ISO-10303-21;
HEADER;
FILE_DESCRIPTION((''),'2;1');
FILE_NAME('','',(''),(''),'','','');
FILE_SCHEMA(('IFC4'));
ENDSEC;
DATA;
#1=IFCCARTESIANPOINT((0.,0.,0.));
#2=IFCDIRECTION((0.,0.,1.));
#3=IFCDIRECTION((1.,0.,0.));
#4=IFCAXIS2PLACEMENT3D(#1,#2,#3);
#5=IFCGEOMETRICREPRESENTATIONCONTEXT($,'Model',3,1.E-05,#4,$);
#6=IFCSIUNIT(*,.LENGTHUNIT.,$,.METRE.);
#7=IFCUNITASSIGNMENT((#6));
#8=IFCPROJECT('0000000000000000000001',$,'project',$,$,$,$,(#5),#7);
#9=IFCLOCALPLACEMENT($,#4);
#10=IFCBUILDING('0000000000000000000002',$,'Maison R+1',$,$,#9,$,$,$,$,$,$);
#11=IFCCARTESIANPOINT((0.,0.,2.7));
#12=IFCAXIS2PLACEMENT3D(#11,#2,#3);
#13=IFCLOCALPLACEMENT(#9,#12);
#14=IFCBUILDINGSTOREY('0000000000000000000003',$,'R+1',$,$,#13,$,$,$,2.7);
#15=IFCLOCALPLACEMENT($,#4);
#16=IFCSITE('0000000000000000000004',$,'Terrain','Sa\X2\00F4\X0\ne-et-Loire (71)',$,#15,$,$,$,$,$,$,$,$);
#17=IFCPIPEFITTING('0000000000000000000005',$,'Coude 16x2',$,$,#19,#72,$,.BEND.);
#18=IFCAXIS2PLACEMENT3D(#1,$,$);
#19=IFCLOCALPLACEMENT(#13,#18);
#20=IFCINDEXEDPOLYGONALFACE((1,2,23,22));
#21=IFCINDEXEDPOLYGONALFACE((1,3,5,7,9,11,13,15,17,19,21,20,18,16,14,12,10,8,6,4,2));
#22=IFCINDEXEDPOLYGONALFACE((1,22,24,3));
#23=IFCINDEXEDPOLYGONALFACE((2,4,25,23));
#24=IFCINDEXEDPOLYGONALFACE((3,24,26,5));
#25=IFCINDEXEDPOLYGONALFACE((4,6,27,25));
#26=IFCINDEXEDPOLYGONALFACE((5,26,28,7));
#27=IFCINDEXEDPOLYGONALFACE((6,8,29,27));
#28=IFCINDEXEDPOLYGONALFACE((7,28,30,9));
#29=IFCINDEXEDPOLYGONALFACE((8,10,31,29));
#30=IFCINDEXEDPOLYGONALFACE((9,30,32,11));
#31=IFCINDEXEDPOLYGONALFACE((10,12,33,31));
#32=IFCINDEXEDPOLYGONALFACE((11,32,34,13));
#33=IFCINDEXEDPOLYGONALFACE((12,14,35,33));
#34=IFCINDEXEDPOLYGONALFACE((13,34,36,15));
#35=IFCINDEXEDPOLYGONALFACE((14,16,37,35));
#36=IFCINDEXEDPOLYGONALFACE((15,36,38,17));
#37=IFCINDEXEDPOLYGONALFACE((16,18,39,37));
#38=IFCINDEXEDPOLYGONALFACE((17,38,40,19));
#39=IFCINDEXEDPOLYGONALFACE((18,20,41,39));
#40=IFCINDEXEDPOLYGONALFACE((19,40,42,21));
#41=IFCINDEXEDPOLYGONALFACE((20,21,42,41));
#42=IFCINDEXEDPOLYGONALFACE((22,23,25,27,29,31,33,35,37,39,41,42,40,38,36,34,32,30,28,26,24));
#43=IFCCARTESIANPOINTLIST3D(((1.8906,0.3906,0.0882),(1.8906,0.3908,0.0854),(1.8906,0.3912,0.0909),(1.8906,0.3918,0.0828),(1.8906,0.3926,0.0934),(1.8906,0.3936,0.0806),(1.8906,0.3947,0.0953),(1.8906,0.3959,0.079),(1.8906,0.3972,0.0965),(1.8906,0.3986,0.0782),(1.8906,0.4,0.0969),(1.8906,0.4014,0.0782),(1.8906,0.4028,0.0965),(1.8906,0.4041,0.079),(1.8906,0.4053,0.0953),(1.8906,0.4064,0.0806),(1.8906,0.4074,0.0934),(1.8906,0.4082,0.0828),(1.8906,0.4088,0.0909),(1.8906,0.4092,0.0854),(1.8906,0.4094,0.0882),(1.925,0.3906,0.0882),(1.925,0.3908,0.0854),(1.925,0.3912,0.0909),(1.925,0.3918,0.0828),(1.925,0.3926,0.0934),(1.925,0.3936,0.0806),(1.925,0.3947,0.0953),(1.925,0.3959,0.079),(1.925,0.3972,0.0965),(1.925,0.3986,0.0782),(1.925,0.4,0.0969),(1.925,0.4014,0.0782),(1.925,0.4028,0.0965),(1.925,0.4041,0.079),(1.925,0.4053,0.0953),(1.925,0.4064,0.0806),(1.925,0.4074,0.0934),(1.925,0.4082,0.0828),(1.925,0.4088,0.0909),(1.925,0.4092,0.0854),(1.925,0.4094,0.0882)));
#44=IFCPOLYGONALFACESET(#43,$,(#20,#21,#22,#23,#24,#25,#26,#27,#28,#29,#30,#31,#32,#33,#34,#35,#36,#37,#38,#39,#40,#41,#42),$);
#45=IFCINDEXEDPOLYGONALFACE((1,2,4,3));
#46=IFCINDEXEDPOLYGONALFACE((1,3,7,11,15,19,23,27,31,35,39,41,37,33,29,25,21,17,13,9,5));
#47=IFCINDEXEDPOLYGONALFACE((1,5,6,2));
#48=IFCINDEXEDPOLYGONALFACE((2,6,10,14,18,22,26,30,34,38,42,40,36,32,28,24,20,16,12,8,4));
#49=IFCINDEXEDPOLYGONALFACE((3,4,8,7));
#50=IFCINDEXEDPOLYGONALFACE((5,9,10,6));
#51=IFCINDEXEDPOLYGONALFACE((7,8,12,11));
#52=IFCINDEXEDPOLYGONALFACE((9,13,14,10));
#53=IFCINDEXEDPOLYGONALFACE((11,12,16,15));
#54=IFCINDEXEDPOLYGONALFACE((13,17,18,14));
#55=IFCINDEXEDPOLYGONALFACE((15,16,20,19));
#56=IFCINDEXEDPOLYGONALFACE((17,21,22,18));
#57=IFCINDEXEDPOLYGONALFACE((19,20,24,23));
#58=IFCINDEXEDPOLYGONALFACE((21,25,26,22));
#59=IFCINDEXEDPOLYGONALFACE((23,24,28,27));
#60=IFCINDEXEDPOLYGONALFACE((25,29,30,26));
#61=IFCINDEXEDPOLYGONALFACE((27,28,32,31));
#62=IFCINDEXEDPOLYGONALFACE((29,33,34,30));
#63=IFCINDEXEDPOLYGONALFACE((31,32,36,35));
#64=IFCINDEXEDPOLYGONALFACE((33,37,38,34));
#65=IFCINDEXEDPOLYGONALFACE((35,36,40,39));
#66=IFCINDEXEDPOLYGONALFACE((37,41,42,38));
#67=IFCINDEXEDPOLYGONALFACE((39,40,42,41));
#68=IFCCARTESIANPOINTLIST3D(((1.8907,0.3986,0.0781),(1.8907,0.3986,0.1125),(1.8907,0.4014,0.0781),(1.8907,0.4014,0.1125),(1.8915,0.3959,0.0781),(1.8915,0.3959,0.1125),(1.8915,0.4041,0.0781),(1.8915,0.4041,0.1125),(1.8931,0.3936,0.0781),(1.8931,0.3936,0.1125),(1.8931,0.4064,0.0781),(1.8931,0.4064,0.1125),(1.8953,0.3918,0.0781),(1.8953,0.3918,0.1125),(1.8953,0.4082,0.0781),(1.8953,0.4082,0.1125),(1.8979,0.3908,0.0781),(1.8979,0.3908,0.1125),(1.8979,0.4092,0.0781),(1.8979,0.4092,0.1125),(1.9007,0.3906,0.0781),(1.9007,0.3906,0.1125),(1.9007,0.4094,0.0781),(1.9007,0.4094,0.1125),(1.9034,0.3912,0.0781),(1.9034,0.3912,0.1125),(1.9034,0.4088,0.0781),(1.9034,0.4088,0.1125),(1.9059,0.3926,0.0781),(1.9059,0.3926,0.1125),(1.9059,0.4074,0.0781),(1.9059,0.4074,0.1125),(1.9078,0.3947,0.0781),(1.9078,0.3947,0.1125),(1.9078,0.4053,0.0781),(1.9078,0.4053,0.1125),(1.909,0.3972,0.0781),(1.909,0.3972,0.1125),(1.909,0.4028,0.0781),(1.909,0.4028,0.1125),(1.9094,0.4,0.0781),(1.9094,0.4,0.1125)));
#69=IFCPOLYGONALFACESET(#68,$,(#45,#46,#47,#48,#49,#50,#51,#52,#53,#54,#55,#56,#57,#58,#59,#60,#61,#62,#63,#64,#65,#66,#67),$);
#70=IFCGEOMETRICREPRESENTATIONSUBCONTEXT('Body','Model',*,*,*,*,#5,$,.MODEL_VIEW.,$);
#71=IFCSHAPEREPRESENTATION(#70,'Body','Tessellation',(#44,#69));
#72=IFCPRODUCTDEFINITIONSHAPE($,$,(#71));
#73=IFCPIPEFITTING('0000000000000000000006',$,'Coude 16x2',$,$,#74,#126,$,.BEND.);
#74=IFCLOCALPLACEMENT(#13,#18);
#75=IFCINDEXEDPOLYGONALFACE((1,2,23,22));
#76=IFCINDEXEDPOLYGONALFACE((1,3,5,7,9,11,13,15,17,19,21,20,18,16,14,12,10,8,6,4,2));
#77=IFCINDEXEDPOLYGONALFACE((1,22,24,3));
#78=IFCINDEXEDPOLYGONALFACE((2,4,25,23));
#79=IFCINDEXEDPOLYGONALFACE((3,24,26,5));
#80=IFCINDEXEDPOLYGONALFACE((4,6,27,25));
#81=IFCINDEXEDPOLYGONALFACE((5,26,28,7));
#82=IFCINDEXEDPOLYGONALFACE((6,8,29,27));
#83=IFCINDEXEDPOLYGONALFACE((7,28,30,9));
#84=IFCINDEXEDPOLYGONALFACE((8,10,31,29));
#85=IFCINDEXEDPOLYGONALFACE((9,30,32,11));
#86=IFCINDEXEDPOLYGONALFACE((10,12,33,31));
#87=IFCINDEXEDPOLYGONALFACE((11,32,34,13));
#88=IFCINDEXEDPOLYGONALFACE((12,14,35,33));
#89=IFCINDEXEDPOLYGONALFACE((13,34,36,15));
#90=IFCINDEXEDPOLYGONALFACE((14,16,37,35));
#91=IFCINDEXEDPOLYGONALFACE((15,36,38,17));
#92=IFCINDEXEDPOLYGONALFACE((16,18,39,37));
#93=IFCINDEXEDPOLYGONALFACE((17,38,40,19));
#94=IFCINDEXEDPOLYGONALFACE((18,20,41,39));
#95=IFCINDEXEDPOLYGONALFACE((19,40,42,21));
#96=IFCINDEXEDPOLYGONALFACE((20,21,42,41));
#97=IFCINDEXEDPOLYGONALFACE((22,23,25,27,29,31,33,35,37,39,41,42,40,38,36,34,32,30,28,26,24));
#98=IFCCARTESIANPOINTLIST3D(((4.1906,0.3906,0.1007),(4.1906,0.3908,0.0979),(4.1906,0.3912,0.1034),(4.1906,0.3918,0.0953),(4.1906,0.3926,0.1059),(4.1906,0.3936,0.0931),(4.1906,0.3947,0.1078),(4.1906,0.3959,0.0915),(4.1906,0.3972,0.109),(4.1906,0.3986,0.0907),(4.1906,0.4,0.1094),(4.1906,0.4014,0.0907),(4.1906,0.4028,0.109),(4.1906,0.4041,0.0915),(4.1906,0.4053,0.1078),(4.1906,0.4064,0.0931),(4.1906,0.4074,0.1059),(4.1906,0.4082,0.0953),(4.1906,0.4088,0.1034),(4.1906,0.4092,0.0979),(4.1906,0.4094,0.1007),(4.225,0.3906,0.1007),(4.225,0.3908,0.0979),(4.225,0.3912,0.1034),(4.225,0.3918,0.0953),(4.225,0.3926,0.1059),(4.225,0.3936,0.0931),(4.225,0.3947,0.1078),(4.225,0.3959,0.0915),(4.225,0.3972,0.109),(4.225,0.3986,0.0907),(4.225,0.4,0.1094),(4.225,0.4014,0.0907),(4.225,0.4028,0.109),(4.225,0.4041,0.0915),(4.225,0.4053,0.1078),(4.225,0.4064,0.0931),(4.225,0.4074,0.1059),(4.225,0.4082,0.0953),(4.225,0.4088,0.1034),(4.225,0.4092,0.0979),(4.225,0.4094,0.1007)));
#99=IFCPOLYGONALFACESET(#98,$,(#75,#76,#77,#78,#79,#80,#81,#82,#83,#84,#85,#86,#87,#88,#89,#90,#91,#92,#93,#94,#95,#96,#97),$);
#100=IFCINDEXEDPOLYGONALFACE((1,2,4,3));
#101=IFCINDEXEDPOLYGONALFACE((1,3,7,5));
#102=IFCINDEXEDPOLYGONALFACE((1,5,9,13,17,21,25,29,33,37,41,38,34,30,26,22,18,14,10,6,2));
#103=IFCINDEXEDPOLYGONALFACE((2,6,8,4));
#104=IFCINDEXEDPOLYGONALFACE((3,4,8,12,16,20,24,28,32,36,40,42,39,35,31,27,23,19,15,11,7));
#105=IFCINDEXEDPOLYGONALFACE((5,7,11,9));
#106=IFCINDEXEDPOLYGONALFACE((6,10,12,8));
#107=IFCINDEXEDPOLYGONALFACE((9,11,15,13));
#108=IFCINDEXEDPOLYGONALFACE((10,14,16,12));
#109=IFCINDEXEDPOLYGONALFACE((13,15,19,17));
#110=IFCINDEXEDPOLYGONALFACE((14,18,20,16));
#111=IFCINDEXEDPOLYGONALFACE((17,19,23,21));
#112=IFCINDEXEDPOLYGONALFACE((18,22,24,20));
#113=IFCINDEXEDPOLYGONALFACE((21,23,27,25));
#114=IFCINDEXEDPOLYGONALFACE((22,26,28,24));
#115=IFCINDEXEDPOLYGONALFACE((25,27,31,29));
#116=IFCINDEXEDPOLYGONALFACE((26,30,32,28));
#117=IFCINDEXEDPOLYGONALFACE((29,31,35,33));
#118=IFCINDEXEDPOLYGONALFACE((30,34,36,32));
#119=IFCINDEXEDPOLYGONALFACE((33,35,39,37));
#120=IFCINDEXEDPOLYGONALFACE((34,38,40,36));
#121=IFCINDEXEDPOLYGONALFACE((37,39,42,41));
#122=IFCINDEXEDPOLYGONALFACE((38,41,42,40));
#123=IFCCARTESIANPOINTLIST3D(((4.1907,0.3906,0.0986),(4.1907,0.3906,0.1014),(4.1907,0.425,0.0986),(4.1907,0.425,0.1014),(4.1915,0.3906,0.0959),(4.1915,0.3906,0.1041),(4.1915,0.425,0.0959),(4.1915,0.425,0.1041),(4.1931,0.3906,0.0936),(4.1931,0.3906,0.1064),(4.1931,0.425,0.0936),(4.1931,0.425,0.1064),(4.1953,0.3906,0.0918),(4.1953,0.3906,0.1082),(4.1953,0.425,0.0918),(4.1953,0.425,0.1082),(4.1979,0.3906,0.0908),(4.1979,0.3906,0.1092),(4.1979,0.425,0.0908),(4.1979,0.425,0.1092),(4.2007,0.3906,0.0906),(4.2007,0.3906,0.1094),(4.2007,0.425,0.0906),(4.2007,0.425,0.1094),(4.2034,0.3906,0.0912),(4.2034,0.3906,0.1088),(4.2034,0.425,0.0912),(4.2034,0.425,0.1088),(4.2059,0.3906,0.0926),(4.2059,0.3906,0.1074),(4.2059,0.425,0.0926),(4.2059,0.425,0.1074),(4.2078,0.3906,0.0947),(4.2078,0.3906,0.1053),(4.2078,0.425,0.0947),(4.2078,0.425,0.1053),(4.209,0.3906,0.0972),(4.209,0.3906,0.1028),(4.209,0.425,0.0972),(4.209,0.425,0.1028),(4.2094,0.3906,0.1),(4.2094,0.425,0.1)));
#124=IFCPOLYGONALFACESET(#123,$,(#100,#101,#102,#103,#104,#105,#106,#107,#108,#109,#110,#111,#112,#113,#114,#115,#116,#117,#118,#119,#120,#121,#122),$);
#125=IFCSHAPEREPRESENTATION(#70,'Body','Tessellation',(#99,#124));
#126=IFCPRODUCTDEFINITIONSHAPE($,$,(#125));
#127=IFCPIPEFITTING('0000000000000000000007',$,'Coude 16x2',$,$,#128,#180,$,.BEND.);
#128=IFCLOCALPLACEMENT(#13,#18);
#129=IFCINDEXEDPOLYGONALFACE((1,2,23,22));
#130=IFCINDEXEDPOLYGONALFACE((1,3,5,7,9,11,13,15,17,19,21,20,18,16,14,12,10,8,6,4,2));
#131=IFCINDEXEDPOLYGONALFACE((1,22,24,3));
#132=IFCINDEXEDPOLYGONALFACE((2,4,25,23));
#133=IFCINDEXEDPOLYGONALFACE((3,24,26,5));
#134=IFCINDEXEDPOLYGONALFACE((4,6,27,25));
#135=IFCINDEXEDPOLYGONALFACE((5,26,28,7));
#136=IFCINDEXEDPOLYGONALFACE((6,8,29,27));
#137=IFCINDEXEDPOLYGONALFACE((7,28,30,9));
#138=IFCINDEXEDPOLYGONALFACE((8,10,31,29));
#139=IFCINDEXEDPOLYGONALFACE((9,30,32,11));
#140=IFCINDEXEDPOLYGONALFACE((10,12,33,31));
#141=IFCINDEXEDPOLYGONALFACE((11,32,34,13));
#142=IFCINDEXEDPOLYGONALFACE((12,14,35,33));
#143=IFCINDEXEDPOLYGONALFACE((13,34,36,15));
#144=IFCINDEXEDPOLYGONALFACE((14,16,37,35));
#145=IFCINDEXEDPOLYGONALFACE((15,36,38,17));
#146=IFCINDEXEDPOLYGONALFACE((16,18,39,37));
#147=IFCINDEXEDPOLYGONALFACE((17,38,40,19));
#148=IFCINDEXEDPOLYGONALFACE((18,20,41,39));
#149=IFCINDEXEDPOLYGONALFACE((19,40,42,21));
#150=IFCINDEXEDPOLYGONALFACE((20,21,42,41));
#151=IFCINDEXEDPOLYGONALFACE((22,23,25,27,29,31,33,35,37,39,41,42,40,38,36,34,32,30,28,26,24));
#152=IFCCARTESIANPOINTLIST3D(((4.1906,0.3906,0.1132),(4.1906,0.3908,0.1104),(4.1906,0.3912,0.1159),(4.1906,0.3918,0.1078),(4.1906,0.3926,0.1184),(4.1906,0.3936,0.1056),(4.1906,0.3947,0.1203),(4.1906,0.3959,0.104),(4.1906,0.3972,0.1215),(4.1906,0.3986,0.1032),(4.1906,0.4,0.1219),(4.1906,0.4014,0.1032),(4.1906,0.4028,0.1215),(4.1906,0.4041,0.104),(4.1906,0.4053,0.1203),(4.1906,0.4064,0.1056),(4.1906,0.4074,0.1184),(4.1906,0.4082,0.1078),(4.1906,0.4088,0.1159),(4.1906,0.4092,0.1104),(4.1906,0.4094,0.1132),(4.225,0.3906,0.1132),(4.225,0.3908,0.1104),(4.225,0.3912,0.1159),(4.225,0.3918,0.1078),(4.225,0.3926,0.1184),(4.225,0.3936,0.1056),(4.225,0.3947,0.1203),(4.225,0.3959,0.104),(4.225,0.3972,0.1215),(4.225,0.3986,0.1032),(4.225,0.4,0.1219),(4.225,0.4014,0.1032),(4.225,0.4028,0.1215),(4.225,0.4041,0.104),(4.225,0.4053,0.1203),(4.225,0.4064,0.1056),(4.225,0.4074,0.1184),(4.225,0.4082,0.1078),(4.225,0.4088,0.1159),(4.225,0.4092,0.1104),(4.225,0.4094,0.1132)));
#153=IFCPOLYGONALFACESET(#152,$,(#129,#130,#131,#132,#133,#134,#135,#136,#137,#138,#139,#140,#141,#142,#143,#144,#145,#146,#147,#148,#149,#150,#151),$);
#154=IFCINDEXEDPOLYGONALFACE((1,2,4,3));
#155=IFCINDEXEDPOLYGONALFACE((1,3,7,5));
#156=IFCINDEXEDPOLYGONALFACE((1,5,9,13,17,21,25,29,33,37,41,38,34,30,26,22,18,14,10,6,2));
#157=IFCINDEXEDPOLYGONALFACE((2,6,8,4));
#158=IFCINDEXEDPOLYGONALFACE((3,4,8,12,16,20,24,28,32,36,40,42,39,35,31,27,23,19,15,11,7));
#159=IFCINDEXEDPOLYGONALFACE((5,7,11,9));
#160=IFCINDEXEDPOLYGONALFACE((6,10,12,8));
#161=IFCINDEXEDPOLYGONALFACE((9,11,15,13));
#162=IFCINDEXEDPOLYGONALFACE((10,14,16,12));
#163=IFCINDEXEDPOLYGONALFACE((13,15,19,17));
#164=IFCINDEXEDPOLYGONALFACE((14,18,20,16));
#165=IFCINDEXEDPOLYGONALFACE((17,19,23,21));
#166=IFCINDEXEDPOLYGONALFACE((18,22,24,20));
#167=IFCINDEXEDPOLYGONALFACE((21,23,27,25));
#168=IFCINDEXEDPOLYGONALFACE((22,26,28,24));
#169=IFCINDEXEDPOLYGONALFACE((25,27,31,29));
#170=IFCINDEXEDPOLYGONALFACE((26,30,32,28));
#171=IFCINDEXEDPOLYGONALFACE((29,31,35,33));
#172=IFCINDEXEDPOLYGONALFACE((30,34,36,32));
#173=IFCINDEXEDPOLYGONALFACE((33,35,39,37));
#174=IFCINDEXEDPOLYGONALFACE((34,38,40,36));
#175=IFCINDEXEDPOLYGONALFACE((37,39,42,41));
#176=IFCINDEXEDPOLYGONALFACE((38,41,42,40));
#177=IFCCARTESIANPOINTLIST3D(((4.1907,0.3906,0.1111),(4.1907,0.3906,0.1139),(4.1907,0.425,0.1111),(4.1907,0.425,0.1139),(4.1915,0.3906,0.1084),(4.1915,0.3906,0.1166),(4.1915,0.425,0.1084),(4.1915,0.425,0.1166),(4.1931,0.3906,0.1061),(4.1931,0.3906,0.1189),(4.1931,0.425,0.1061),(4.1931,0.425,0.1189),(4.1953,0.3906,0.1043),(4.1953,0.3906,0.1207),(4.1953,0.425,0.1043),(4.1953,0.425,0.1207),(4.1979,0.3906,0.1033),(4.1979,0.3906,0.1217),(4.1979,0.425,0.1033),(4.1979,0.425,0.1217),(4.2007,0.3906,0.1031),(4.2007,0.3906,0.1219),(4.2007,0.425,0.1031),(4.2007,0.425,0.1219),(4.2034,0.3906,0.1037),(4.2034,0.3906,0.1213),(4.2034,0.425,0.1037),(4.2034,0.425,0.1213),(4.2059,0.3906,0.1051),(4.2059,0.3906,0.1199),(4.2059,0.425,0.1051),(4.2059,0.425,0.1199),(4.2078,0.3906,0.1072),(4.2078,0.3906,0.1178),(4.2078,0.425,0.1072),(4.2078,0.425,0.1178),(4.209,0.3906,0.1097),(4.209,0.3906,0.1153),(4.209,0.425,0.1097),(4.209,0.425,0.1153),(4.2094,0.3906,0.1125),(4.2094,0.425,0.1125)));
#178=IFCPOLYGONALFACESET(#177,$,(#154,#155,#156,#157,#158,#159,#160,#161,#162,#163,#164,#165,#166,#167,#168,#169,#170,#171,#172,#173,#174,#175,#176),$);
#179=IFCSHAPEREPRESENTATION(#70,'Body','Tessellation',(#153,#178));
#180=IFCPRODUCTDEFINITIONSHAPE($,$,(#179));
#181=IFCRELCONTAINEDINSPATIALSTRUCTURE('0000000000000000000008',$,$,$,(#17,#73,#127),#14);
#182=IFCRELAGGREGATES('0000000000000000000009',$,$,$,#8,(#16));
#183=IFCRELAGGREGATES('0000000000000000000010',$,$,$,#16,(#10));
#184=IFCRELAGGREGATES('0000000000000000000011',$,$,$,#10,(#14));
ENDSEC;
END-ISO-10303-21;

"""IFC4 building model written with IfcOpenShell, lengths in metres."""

from ifc_helpers import new_model, si_unit, frame, origin_with_axes, place, context, subcontext, project, spatial, circle, extrude, element, save


model = new_model("IFC4")

# Units and contexts
model_context = context("Model", 3, precision=1e-05, world=origin_with_axes())
body_context = subcontext(model_context, "Body", "Model", "MODEL_VIEW")
ifc_project = project(units=[si_unit("LENGTHUNIT", "METRE")], contexts=[model_context])

# Site, building, storey
site_placement = place(None, origin_with_axes())
site = spatial("IfcSite", under=ifc_project, at=site_placement, Name="Terrain", Description="Saône-et-Loire (71)")
building_placement = place(None, origin_with_axes())
building = spatial("IfcBuilding", under=site, at=building_placement, Name="Maison R+1")
storey_placement = place(building_placement, frame((0.0, 0.0, 2.7), z_axis=(0.0, 0.0, 1.0), x_axis=(1.0, 0.0, 0.0)))
storey = spatial("IfcBuildingStorey", under=building, at=storey_placement, Name="R+1", Elevation=2.7)

# Pipe fittings
for number, where, z_axis, x_axis, name in (
    (1, (1.9, 0.4, 0.0875), (0.0, 0.0, 1.0), (1.0, 0.0, 0.0), "Coude 16x2"),
):
    element("IfcPipeFitting", number, at=place(storey_placement, frame(where, z_axis=z_axis, x_axis=x_axis)), inside=storey, Name=name, PredefinedType="BEND", context=body_context, shape_type="SweptSolid", body=[
        extrude(circle(Radius=0.0094), frame((-0.0094, 0.0, 0.0), z_axis=(1.0, 0.0, 0.0), x_axis=(0.0, 0.0, 1.0)), (0.0, 0.0, 1.0), 0.0344),
        extrude(circle(Radius=0.0094), frame((0.0, 0.0, -0.0094), z_axis=(0.0, 0.0, 1.0), x_axis=(1.0, 0.0, 0.0)), (0.0, 0.0, 1.0), 0.0344),
    ])
for number, where, z_axis, x_axis, name in (
    (2, (4.2, 0.4, 0.1), (0.0, 0.0, 1.0), (1.0, 0.0, 0.0), "Coude 16x2"),
    (3, (4.2, 0.4, 0.1125), (0.0, 0.0, 1.0), (1.0, 0.0, 0.0), "Coude 16x2"),
):
    element("IfcPipeFitting", number, at=place(storey_placement, frame(where, z_axis=z_axis, x_axis=x_axis)), inside=storey, Name=name, PredefinedType="BEND", context=body_context, shape_type="SweptSolid", body=[
        extrude(circle(Radius=0.0094), frame((-0.0094, 0.0, 0.0), z_axis=(1.0, 0.0, 0.0), x_axis=(0.0, 0.0, 1.0)), (0.0, 0.0, 1.0), 0.0344),
        extrude(circle(Radius=0.0094), frame((0.0, -0.0094, 0.0), z_axis=(0.0, 1.0, 0.0), x_axis=(1.0, 0.0, 0.0)), (0.0, 0.0, 1.0), 0.0344),
    ])

save(model, "model.ifc")
